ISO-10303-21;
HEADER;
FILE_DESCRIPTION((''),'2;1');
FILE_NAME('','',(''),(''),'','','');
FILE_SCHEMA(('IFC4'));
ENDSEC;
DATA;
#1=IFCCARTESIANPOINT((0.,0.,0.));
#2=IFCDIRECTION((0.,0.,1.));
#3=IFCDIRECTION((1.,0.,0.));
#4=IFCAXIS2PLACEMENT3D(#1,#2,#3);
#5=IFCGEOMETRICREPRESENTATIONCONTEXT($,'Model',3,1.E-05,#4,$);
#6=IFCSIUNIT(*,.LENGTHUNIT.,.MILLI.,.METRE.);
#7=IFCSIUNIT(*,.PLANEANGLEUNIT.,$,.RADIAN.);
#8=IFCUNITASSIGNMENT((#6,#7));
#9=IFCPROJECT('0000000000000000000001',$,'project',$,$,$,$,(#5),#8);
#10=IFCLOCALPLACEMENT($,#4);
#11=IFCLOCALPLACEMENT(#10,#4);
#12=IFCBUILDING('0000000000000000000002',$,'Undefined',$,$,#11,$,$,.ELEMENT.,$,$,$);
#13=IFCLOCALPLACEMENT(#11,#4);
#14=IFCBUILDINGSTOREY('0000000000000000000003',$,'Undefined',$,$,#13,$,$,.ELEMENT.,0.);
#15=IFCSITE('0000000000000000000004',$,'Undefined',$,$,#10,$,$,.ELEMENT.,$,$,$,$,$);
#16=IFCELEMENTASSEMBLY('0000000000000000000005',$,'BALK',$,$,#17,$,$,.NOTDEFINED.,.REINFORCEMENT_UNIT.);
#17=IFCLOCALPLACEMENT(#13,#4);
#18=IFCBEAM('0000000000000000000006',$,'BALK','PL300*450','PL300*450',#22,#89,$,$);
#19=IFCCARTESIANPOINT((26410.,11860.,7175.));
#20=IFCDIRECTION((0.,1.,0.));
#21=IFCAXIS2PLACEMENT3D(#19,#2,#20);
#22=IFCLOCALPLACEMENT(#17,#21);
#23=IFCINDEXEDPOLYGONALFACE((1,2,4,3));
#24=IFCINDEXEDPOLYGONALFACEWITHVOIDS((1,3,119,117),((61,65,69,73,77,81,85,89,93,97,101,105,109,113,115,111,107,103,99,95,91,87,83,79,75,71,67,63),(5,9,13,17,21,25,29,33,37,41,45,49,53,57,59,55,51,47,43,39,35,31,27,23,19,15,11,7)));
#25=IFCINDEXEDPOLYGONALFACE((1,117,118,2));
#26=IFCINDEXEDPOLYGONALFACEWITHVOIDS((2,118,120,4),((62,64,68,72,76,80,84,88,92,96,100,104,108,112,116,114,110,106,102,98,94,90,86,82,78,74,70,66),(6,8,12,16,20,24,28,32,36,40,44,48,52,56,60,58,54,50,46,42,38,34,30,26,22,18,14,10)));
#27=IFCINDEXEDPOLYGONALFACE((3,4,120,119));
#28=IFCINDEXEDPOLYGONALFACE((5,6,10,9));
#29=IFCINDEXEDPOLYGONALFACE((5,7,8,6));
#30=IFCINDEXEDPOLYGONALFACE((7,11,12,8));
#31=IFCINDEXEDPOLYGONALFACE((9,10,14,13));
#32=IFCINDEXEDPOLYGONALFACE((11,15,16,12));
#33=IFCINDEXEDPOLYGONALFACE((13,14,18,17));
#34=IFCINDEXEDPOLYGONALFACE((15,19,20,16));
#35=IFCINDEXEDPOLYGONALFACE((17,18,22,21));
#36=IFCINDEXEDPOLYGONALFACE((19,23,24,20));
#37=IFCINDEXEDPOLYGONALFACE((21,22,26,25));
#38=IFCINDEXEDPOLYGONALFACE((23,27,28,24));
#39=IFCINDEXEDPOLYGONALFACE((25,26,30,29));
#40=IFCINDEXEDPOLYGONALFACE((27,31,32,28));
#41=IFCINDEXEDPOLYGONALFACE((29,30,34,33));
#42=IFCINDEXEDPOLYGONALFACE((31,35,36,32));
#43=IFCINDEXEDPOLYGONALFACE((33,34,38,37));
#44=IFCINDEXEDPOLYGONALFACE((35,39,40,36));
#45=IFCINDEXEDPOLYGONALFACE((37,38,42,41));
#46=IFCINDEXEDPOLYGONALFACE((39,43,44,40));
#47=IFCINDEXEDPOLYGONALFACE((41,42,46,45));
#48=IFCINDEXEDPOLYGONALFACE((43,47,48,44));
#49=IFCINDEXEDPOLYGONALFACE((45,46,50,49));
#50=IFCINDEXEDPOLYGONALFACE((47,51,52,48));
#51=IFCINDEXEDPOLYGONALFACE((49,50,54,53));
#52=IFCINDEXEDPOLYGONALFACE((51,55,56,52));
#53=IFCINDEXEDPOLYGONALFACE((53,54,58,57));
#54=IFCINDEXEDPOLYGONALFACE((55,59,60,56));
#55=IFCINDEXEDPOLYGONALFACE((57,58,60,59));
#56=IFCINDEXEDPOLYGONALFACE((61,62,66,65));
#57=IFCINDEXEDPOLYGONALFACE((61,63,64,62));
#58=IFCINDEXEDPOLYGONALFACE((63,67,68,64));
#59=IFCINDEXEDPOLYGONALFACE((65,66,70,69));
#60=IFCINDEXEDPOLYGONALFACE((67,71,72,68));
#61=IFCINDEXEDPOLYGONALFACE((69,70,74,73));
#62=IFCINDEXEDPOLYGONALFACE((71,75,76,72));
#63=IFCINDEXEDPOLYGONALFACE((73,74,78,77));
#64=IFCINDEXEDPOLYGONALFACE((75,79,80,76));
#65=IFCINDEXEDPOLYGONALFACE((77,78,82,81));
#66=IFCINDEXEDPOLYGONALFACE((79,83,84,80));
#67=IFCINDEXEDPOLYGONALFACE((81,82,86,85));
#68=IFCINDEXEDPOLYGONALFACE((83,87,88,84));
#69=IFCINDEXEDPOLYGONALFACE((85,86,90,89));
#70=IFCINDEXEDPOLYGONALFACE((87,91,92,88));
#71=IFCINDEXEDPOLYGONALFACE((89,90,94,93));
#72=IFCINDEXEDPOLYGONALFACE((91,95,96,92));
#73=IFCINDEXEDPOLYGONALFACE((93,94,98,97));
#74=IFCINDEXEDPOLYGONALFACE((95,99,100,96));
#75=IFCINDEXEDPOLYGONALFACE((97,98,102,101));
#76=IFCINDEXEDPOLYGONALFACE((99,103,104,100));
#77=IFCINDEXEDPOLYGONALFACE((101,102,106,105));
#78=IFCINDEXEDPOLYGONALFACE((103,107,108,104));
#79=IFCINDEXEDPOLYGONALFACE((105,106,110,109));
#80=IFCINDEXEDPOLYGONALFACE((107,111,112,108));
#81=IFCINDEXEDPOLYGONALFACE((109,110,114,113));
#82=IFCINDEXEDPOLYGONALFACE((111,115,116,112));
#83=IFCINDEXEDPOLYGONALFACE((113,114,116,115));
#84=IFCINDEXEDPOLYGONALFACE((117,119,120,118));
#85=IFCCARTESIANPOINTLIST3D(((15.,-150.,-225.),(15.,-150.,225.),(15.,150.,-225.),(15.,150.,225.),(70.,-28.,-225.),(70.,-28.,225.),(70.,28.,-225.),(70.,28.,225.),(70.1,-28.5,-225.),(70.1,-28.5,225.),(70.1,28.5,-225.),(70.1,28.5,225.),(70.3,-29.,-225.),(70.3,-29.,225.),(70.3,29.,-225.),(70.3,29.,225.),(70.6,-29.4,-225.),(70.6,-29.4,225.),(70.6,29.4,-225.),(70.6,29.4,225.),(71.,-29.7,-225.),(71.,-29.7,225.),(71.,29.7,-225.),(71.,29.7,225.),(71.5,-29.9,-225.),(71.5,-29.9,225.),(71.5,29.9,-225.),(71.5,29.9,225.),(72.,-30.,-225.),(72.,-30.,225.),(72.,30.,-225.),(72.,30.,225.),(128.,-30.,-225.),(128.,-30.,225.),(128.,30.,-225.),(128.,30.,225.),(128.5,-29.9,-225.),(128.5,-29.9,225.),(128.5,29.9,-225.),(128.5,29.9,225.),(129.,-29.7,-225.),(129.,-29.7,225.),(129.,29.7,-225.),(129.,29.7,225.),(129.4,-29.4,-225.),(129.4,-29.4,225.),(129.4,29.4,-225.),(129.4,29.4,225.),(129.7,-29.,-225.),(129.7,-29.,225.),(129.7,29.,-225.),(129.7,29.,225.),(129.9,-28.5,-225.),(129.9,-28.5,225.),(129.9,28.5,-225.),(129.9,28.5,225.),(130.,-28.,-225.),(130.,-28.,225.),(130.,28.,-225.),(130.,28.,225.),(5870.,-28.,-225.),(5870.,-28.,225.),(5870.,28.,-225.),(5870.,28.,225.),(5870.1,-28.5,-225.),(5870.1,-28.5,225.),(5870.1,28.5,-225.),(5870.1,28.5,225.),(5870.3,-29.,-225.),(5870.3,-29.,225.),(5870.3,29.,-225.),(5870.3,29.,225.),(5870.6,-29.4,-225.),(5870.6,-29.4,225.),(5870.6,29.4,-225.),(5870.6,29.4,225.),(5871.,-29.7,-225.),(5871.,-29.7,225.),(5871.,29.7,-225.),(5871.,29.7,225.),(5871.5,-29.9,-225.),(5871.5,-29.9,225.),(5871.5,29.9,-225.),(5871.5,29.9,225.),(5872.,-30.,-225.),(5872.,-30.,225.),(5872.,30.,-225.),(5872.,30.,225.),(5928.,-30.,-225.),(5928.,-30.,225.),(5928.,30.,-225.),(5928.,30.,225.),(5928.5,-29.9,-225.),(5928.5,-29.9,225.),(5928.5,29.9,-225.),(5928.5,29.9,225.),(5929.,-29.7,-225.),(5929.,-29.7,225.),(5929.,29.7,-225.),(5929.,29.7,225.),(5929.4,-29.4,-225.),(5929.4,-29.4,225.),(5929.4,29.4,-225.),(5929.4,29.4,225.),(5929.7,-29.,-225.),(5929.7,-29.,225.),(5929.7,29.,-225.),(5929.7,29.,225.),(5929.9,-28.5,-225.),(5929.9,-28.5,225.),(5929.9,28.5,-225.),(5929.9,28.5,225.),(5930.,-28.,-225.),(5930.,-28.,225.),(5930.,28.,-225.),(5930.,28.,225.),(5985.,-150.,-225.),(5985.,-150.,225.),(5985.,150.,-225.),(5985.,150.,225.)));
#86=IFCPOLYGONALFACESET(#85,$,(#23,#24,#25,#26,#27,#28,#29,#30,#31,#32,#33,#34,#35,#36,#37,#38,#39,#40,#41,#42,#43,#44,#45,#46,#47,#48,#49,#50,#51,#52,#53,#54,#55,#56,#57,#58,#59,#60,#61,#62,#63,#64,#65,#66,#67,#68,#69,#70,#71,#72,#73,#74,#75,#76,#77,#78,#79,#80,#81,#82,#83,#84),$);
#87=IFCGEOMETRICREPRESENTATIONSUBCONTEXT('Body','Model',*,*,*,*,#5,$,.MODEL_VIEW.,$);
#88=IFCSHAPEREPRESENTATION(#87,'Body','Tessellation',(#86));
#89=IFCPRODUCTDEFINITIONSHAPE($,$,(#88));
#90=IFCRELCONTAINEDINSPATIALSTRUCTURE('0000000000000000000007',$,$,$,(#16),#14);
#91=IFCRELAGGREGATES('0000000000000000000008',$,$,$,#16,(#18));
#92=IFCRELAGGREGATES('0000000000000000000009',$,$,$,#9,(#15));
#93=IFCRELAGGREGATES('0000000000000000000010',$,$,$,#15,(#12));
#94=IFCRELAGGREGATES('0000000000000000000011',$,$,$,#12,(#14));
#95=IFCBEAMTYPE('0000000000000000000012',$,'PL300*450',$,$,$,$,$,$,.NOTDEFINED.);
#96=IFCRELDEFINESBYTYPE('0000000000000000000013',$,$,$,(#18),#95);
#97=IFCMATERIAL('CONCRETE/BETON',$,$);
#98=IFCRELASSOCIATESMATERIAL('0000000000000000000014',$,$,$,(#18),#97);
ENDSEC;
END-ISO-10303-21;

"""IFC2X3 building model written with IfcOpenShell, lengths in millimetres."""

from ifc_helpers import new_model, si_unit, frame, frame_2d, origin_with_axes, place, context, subcontext, project, spatial, rectangle, rounded_rectangle, extrude, boolean, halfspace, material, type_object, element, aggregate, save


model = new_model("IFC2X3")

# Units and contexts
model_context = context("Model", 3, precision=1e-05, world=origin_with_axes())
body_context = subcontext(model_context, "Body", "Model", "MODEL_VIEW")
ifc_project = project(units=[si_unit("LENGTHUNIT", "METRE", prefix="MILLI"), si_unit("PLANEANGLEUNIT", "RADIAN")], contexts=[model_context])

# Site, building, storey
site_placement = place(None, origin_with_axes())
site = spatial("IfcSite", under=ifc_project, at=site_placement, Name="Undefined", CompositionType="ELEMENT")
building_placement = place(site_placement, origin_with_axes())
building = spatial("IfcBuilding", under=site, at=building_placement, Name="Undefined", CompositionType="ELEMENT")
storey_placement = place(building_placement, origin_with_axes())
storey = spatial("IfcBuildingStorey", under=building, at=storey_placement, Name="Undefined", CompositionType="ELEMENT", Elevation=0.0)

# Shared definitions
ifc_material_1 = material(Name="CONCRETE/BETON")

# Element assembly
assembly_1_placement = place(storey_placement, origin_with_axes())
assembly_1 = element("IfcElementAssembly", 1, at=assembly_1_placement, inside=storey, Name="BALK", AssemblyPlace="NOTDEFINED", PredefinedType="REINFORCEMENT_UNIT")

# Beam
beam_type_1 = type_object("IfcBeamType", Name="PL300*450", PredefinedType="NOTDEFINED")
beam_1_placement = place(assembly_1_placement, frame((26410.0, 11860.0, 7175.0), z_axis=(0.0, 0.0, 1.0), x_axis=(0.0, 1.0, 0.0)))
beam_1 = element("IfcBeam", 2, at=beam_1_placement, type_object=beam_type_1, material=ifc_material_1, Name="BALK", Description="PL300*450", ObjectType="PL300*450", context=body_context, shape_type="CSG", body=[
    boolean("DIFFERENCE", boolean("DIFFERENCE", boolean("DIFFERENCE", boolean("DIFFERENCE", extrude(rectangle(XDim=300.0, YDim=450.0, at=frame_2d((0.0, 0.0), x_axis=(1.0, 0.0))), frame((5985.0, 0.0, 0.0), z_axis=(-1.0, 0.0, 0.0), x_axis=(0.0, -1.0, 0.0)), (0.0, 0.0, 1.0), 5970.0), extrude(rounded_rectangle(XDim=60.0, YDim=60.0, RoundingRadius=2.0, at=frame_2d((0.0, 0.0), x_axis=(1.0, 0.0))), frame((100.0, 0.0, 275.0), z_axis=(0.0, 0.0, -1.0), x_axis=(1.0, 0.0, 0.0)), (0.0, 0.0, 1.0), 508.0)), extrude(rounded_rectangle(XDim=60.0, YDim=60.0, RoundingRadius=2.0, at=frame_2d((0.0, 0.0), x_axis=(1.0, 0.0))), frame((5900.0, 0.0, 275.0), z_axis=(0.0, 0.0, -1.0), x_axis=(-1.0, 0.0, 0.0)), (0.0, 0.0, 1.0), 508.0)), halfspace(frame((5985.0, 0.0, 10.0), z_axis=(1.0, 0.0, 0.0), x_axis=(0.0, 1.0, 0.0)), False)), halfspace(frame((15.0, 0.0, 10.0), z_axis=(-1.0, 0.0, 0.0), x_axis=(0.0, -1.0, 0.0)), False)),
])
aggregate(assembly_1, [beam_1])

save(model, "model.ifc")
